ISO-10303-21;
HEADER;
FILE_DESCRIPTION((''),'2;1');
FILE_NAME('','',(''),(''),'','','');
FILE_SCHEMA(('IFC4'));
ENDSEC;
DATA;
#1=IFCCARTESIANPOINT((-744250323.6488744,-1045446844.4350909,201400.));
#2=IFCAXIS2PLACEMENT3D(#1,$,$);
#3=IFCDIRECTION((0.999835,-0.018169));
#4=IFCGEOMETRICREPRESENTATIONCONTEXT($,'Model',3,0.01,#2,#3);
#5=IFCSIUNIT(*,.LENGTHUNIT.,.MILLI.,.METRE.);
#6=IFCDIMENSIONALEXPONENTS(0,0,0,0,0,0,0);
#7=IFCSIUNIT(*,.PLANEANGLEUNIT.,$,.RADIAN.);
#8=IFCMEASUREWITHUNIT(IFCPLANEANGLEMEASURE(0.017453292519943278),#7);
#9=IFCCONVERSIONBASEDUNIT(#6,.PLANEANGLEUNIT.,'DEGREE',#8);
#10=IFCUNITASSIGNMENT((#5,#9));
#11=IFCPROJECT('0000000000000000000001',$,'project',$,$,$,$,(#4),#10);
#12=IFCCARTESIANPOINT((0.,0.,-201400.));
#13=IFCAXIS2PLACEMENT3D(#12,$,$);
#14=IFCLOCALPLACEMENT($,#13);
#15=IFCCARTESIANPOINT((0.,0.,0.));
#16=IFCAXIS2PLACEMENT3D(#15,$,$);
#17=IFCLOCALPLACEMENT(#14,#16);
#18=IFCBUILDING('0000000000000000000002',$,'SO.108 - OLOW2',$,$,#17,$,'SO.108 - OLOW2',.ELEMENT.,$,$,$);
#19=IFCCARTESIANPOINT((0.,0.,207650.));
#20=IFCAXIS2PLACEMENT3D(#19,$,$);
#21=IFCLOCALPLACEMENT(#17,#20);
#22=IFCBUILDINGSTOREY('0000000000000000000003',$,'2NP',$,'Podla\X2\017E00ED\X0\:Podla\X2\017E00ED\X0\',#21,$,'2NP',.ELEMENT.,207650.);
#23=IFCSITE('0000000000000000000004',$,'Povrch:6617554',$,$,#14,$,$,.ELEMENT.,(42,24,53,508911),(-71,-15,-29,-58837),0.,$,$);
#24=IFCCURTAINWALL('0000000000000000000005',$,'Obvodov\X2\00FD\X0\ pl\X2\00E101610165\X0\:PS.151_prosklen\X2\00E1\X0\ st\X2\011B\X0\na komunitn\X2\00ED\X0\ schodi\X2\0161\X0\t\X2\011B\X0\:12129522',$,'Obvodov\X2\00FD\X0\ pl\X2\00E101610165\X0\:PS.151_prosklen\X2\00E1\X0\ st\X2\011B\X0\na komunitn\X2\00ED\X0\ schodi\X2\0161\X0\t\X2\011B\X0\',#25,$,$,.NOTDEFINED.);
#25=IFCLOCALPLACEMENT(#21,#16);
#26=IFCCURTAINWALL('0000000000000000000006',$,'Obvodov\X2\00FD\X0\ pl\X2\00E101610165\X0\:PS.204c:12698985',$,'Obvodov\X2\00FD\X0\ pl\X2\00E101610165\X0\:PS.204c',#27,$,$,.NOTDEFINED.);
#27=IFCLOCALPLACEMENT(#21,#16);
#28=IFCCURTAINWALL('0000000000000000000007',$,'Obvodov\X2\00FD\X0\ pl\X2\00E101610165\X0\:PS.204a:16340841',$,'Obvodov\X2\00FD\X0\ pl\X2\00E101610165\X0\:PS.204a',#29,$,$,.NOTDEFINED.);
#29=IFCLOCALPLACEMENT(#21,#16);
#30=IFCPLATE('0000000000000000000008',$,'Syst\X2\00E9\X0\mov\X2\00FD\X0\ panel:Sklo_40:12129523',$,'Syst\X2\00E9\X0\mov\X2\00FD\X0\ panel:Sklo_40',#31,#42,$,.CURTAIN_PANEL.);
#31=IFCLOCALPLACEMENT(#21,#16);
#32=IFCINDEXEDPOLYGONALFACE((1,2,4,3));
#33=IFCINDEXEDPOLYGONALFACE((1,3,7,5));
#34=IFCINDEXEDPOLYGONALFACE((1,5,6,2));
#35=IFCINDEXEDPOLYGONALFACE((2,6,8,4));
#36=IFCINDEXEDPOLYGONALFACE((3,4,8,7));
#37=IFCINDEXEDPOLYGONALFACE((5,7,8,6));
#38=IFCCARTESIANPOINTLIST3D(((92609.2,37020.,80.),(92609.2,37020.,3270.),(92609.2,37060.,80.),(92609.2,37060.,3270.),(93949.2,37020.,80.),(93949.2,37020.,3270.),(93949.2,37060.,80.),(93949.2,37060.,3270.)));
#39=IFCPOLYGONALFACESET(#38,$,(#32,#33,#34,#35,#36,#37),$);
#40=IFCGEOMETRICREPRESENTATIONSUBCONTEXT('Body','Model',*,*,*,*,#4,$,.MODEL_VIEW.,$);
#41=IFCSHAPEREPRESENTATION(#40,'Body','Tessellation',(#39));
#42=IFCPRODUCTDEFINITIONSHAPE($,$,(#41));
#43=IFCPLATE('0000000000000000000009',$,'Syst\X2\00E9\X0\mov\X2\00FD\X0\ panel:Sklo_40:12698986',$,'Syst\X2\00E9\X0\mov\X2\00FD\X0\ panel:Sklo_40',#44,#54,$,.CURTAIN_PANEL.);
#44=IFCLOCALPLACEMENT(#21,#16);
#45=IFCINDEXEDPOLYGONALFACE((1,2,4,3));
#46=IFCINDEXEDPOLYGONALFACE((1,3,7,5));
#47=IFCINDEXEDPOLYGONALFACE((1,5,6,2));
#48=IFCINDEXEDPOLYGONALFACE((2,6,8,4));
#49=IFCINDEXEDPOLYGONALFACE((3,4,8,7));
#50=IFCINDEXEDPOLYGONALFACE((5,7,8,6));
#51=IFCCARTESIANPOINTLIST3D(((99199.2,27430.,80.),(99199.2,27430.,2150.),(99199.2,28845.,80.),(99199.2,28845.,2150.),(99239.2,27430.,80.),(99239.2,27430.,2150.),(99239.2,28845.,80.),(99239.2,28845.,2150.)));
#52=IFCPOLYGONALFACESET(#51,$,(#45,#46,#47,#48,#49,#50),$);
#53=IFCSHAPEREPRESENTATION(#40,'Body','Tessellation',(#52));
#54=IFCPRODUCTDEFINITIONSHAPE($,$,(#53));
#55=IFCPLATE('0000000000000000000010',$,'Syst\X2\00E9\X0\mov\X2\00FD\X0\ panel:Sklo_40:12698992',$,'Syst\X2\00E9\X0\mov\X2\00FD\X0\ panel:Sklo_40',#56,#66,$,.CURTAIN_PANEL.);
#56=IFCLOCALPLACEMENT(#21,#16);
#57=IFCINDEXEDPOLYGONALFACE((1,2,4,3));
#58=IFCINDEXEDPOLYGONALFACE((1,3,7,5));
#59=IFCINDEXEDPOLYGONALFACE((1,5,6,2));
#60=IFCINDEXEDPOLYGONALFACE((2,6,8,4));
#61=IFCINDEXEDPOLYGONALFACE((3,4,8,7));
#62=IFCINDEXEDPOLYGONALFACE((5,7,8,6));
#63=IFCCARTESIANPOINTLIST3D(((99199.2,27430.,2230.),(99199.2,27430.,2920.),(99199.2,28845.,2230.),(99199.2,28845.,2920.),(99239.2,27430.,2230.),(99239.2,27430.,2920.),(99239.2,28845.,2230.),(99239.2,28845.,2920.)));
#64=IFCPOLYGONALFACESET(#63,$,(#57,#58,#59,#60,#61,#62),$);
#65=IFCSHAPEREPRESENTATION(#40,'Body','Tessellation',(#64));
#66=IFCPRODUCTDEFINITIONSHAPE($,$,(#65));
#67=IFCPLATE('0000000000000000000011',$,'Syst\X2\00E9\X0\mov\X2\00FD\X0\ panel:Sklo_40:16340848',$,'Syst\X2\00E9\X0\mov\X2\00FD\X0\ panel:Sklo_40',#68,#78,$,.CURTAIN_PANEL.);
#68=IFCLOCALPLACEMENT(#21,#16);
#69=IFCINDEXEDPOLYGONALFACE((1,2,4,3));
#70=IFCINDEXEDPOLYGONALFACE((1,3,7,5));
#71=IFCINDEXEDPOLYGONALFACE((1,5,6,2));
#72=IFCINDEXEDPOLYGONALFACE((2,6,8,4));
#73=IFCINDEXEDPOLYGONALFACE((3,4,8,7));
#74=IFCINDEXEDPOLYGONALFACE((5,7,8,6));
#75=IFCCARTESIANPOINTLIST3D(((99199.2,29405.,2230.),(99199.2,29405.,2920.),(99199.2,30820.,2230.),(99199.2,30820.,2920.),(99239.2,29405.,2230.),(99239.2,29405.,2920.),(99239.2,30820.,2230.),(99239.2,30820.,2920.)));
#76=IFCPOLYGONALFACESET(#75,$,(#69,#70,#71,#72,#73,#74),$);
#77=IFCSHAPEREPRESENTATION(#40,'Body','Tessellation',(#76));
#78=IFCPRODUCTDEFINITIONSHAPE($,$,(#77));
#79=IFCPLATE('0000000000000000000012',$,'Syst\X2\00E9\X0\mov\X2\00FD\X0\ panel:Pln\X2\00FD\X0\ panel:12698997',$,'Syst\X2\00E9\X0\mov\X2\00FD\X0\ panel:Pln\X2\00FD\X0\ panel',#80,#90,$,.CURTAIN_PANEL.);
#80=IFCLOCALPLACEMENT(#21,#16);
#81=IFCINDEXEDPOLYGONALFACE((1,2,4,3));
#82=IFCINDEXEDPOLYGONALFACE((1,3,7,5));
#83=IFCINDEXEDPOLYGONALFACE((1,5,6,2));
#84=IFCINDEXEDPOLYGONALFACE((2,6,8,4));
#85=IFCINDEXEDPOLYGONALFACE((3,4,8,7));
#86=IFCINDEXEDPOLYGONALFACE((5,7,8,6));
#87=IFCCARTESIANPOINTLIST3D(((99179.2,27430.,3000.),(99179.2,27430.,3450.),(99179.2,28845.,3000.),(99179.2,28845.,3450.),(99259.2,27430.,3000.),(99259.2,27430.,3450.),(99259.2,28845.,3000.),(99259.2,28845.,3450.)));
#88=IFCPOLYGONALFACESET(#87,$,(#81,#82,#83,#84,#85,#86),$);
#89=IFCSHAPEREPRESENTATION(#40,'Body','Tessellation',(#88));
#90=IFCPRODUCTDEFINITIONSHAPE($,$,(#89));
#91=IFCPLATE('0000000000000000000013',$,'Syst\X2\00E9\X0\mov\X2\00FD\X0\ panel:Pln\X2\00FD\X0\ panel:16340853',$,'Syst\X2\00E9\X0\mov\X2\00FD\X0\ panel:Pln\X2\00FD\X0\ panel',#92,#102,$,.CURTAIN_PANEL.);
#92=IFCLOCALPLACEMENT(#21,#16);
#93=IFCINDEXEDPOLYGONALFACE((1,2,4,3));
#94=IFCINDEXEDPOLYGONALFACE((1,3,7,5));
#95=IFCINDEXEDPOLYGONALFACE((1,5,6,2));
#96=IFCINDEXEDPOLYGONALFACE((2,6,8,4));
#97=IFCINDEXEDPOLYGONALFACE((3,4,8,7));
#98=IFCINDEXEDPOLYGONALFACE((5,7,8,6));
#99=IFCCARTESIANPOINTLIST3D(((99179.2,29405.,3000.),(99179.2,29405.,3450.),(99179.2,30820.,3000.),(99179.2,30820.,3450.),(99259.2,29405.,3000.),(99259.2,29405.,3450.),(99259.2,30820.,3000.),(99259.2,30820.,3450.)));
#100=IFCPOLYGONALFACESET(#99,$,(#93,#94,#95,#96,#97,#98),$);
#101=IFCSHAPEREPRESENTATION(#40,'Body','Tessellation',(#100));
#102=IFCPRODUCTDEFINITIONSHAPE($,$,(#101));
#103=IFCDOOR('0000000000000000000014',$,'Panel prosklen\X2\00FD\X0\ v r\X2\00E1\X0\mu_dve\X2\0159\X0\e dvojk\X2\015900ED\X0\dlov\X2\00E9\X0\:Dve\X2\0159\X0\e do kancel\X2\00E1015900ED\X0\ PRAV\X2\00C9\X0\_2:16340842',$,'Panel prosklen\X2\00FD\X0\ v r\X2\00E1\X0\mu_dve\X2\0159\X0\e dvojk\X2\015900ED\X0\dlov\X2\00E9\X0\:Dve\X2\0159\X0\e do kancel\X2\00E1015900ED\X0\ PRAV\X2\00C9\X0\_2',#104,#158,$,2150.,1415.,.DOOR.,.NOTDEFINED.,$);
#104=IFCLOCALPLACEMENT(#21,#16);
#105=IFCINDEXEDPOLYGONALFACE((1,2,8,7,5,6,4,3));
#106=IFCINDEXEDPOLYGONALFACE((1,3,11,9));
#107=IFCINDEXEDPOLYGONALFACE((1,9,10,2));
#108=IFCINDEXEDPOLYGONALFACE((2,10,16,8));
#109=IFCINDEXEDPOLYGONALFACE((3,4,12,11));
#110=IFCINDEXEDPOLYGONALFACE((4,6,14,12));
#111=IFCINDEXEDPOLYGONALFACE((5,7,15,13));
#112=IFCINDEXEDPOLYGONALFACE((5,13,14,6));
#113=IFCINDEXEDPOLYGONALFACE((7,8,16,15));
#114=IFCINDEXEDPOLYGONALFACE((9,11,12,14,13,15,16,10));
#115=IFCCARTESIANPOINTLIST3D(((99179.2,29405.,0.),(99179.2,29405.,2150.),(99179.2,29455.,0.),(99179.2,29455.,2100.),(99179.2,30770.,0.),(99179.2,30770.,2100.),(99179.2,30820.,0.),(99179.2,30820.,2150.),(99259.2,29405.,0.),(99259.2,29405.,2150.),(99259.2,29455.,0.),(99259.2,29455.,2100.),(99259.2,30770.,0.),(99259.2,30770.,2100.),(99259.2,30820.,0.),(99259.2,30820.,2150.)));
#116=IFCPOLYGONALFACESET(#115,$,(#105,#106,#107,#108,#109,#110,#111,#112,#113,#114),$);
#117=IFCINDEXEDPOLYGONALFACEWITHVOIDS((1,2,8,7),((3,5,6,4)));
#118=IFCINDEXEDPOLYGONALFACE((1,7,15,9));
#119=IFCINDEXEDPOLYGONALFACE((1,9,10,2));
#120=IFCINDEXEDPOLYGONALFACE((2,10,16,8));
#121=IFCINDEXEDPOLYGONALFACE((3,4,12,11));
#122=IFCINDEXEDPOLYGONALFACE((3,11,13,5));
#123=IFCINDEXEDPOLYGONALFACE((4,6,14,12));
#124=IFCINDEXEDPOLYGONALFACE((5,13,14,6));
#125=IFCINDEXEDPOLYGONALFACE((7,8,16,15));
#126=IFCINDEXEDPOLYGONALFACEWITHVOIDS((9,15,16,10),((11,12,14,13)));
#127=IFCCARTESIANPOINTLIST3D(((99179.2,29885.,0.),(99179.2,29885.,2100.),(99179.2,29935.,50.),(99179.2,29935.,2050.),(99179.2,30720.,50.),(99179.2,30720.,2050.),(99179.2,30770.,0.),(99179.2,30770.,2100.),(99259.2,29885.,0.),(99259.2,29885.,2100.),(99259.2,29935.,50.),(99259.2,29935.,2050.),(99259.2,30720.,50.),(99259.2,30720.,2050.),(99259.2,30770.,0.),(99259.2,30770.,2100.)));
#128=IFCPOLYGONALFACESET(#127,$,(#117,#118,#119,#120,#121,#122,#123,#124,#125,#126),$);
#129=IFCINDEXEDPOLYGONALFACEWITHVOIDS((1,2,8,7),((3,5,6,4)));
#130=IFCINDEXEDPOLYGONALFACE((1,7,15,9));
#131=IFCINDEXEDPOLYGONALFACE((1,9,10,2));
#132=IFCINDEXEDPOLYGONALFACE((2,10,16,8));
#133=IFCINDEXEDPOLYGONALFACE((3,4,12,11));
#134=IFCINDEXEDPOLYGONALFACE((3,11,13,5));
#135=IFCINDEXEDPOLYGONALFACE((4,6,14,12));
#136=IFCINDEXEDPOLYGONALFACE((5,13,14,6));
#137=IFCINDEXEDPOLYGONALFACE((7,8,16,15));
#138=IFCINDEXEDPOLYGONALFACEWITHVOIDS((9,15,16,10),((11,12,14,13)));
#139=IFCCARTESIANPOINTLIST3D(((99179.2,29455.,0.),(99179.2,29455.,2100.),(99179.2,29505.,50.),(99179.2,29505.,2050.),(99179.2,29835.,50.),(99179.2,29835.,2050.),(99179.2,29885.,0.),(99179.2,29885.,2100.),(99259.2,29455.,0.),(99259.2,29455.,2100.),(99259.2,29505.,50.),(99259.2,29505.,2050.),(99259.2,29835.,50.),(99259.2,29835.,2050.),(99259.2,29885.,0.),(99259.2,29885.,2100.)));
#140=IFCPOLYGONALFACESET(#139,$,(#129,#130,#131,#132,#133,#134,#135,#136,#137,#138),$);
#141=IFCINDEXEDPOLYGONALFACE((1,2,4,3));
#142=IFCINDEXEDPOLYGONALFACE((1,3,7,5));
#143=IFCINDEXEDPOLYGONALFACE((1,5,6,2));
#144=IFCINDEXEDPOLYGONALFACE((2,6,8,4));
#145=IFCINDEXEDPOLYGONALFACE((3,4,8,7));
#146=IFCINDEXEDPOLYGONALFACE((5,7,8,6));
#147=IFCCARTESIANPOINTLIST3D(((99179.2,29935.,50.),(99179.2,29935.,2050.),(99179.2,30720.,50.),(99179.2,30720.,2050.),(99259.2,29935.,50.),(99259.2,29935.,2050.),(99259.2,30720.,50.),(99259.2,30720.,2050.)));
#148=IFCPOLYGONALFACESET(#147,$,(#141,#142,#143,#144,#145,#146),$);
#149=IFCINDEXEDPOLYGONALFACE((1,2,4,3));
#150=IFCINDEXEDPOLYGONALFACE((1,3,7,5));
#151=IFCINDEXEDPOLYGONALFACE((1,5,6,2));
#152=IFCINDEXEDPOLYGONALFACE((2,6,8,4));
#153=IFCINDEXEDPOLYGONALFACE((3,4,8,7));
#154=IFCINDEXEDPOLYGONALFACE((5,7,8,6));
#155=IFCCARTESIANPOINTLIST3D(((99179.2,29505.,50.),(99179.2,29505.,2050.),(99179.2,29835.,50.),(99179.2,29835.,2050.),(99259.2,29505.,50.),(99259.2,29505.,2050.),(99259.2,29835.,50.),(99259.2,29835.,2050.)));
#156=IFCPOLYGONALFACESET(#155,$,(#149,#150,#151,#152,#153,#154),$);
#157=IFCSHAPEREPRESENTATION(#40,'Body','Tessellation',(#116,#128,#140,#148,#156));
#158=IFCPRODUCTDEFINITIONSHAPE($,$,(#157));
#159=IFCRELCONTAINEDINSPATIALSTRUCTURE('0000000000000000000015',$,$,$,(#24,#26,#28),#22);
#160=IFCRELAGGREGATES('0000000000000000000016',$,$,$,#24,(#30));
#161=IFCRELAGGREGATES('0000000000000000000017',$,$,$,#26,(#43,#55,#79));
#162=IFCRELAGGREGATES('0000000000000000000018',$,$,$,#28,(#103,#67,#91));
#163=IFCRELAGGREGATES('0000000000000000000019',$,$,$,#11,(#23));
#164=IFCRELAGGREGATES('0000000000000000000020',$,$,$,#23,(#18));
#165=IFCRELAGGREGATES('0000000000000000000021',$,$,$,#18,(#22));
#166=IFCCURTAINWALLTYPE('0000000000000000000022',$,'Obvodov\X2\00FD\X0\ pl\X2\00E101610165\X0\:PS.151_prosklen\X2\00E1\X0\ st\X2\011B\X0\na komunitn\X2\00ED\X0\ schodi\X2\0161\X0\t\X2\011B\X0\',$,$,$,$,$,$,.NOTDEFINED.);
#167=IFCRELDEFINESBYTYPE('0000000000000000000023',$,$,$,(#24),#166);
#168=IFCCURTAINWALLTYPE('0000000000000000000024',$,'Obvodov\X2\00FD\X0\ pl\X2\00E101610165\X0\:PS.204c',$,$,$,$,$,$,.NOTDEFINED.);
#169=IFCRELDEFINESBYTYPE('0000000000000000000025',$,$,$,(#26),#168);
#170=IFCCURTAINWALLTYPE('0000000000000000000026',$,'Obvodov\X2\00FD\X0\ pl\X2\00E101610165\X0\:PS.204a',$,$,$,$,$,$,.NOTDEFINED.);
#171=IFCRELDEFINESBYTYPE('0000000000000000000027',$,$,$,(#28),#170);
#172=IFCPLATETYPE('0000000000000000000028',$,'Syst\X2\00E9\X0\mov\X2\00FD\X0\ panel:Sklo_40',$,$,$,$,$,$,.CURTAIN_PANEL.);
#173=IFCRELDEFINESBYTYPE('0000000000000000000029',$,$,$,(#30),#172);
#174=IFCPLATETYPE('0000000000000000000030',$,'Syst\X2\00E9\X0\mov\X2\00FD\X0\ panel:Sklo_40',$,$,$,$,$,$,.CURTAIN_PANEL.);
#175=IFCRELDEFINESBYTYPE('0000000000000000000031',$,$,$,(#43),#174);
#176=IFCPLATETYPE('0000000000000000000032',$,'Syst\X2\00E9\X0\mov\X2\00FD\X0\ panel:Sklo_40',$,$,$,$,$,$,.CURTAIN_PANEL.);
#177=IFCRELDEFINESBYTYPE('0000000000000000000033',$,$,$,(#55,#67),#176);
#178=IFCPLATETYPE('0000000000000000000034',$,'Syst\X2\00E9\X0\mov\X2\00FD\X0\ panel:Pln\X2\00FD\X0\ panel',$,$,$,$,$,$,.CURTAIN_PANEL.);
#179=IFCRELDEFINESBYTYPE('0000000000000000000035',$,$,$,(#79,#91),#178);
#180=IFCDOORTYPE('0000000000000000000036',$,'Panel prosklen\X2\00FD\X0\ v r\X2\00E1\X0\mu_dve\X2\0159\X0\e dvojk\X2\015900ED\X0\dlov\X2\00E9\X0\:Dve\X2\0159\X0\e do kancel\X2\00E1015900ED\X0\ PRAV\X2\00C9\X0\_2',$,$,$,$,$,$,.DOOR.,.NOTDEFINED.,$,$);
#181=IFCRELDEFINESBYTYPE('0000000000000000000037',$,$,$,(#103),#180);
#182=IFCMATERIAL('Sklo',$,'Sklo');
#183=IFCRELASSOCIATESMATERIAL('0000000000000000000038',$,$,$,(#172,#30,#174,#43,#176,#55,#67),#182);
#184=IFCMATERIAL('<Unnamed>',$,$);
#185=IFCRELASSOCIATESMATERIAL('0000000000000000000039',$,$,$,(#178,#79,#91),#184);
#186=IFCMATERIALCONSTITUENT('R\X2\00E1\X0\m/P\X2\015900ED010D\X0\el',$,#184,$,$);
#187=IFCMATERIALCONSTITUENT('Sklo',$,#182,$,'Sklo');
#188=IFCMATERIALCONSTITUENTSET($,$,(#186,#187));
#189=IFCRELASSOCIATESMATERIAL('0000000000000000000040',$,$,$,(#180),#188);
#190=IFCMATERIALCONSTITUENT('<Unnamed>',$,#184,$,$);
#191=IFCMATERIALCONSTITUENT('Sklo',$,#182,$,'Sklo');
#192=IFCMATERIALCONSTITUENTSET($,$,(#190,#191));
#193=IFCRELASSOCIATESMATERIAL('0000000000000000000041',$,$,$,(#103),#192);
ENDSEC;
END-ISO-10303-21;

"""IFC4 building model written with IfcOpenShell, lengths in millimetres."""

from ifc_helpers import new_model, entity, si_unit, converted_unit, direction, frame, origin, place, context, subcontext, project, spatial, indexed_curve, outline, extrude, source, transform, mapped, material, constituent, constituent_set, type_object, type_shapes, element, aggregate, save


model = new_model("IFC4")

# Units and contexts
model_context = context("Model", 3, precision=0.01, world=frame((-744250323.6488744, -1045446844.4350909, 201400.0)), true_north=direction((0.999835, -0.018169)))
body_context = subcontext(model_context, "Body", "Model", "MODEL_VIEW")
ifc_project = project(units=[si_unit("LENGTHUNIT", "METRE", prefix="MILLI"), converted_unit("PLANEANGLEUNIT", "DEGREE", entity("IfcPlaneAngleMeasure", 0.017453292519943278), si_unit("PLANEANGLEUNIT", "RADIAN"), dimensions=[0, 0, 0, 0, 0, 0, 0])], contexts=[model_context])

# Site, building, storey
site_placement = place(None, frame((0.0, 0.0, -201400.0)))
site = spatial("IfcSite", under=ifc_project, at=site_placement, Name="Povrch:6617554", CompositionType="ELEMENT", RefLatitude=(42, 24, 53, 508911), RefLongitude=(-71, -15, -29, -58837), RefElevation=0.0)
building_placement = place(site_placement, origin())
building = spatial("IfcBuilding", under=site, at=building_placement, Name="SO.108 - OLOW2", LongName="SO.108 - OLOW2", CompositionType="ELEMENT")
storey_placement = place(building_placement, frame((0.0, 0.0, 207650.0)))
storey = spatial("IfcBuildingStorey", under=building, at=storey_placement, Name="2NP", ObjectType="Podlaží:Podlaží", LongName="2NP", CompositionType="ELEMENT", Elevation=207650.0)

# Curtain wall
curtain_wall_type_1 = type_object("IfcCurtainWallType", Name="Obvodový plášť:PS.151_prosklená stěna komunitní schodiště", PredefinedType="NOTDEFINED")
curtain_wall_1_placement = place(storey_placement, frame((0.0, 0.0, -207650.0)))
curtain_wall_1 = element("IfcCurtainWall", 1, at=curtain_wall_1_placement, inside=storey, type_object=curtain_wall_type_1, Name="Obvodový plášť:PS.151_prosklená stěna komunitní schodiště:12129522", ObjectType="Obvodový plášť:PS.151_prosklená stěna komunitní schodiště", PredefinedType="NOTDEFINED")
ifc_material_1 = material(Name="<Unnamed>")

# Curtain walls
curtain_wall_type_2 = type_object("IfcCurtainWallType", Name="Obvodový plášť:PS.204c", PredefinedType="NOTDEFINED")
curtain_wall_2_placement = place(storey_placement, frame((0.0, 0.0, -207650.0)))
curtain_wall_2 = element("IfcCurtainWall", 2, at=curtain_wall_2_placement, inside=storey, type_object=curtain_wall_type_2, Name="Obvodový plášť:PS.204c:12698985", ObjectType="Obvodový plášť:PS.204c", PredefinedType="NOTDEFINED")
curtain_wall_type_3 = type_object("IfcCurtainWallType", Name="Obvodový plášť:PS.204a", PredefinedType="NOTDEFINED")
curtain_wall_3_placement = place(storey_placement, frame((0.0, 0.0, -207650.0)))
curtain_wall_3 = element("IfcCurtainWall", 3, at=curtain_wall_3_placement, inside=storey, type_object=curtain_wall_type_3, Name="Obvodový plášť:PS.204a:16340841", ObjectType="Obvodový plášť:PS.204a", PredefinedType="NOTDEFINED")

# Plates
ifc_material_2 = material(Name="Sklo", Category="Sklo")
plate_type_1 = type_object("IfcPlateType", Name="Systémový panel:Sklo_40", PredefinedType="CURTAIN_PANEL", material=ifc_material_2)
shared_shape_1 = source(origin(), body_context, "Body", "SweptSolid", [
    extrude(outline(indexed_curve([(-20.0, -670.0), (20.0, -670.0), (20.0, 670.0), (-20.0, 670.0), (-20.0, -670.0)], self_intersect=False)), frame((0.0, 0.0, 0.0), z_axis=(0.0, 0.0, 1.0), x_axis=(0.0, 1.0, 0.0)), (0.0, 0.0, 1.0), 3190.0),
])
type_shapes(plate_type_1, [shared_shape_1])
plate_1_placement = place(curtain_wall_1_placement, frame((93279.2, 37040.0, 207730.0)))
plate_1 = element("IfcPlate", 4, at=plate_1_placement, type_object=plate_type_1, material=ifc_material_2, Name="Systémový panel:Sklo_40:12129523", ObjectType="Systémový panel:Sklo_40", PredefinedType="CURTAIN_PANEL", context=body_context, shape_type="MappedRepresentation", body=[
    mapped(shared_shape_1, transform((0.0, 0.0, 0.0), scale=1.0)),
])
aggregate(curtain_wall_1, [plate_1])
plate_type_2 = type_object("IfcPlateType", Name="Systémový panel:Sklo_40", PredefinedType="CURTAIN_PANEL", material=ifc_material_2)
shared_shape_2 = source(origin(), body_context, "Body", "SweptSolid", [
    extrude(outline(indexed_curve([(-20.0, -707.5), (20.0, -707.5), (20.0, 707.5), (-20.0, 707.5), (-20.0, -707.5)], self_intersect=False)), frame((0.0, 0.0, 0.0), z_axis=(0.0, 0.0, 1.0), x_axis=(0.0, 1.0, 0.0)), (0.0, 0.0, 1.0), 2070.0),
])
type_shapes(plate_type_2, [shared_shape_2])
plate_2_placement = place(curtain_wall_2_placement, frame((99219.2, 28137.5, 207730.0), z_axis=(0.0, 0.0, 1.0), x_axis=(0.0, -1.0, 0.0)))
plate_2 = element("IfcPlate", 5, at=plate_2_placement, type_object=plate_type_2, material=ifc_material_2, Name="Systémový panel:Sklo_40:12698986", ObjectType="Systémový panel:Sklo_40", PredefinedType="CURTAIN_PANEL", context=body_context, shape_type="MappedRepresentation", body=[
    mapped(shared_shape_2, transform((0.0, 0.0, 0.0), scale=1.0)),
])
plate_type_3 = type_object("IfcPlateType", Name="Systémový panel:Sklo_40", PredefinedType="CURTAIN_PANEL", material=ifc_material_2)
shared_shape_3 = source(origin(), body_context, "Body", "SweptSolid", [
    extrude(outline(indexed_curve([(-20.0, -707.5), (20.0, -707.5), (20.0, 707.5), (-20.0, 707.5), (-20.0, -707.5)], self_intersect=False)), frame((0.0, 0.0, 0.0), z_axis=(0.0, 0.0, 1.0), x_axis=(0.0, 1.0, 0.0)), (0.0, 0.0, 1.0), 690.0),
])
type_shapes(plate_type_3, [shared_shape_3])
plate_3_placement = place(curtain_wall_2_placement, frame((99219.2, 28137.5, 209880.0), z_axis=(0.0, 0.0, 1.0), x_axis=(0.0, -1.0, 0.0)))
plate_3 = element("IfcPlate", 6, at=plate_3_placement, type_object=plate_type_3, material=ifc_material_2, Name="Systémový panel:Sklo_40:12698992", ObjectType="Systémový panel:Sklo_40", PredefinedType="CURTAIN_PANEL", context=body_context, shape_type="MappedRepresentation", body=[
    mapped(shared_shape_3, transform((0.0, 0.0, 0.0), scale=1.0)),
])
plate_4_placement = place(curtain_wall_3_placement, frame((99219.2, 30112.5, 209880.0), z_axis=(0.0, 0.0, 1.0), x_axis=(0.0, 1.0, 0.0)))
plate_4 = element("IfcPlate", 7, at=plate_4_placement, type_object=plate_type_3, material=ifc_material_2, Name="Systémový panel:Sklo_40:16340848", ObjectType="Systémový panel:Sklo_40", PredefinedType="CURTAIN_PANEL", context=body_context, shape_type="MappedRepresentation", body=[
    mapped(shared_shape_3, transform((0.0, 0.0, 0.0), scale=1.0)),
])
plate_type_4 = type_object("IfcPlateType", Name="Systémový panel:Plný panel", PredefinedType="CURTAIN_PANEL", material=ifc_material_1)
shared_shape_4 = source(origin(), body_context, "Body", "SweptSolid", [
    extrude(outline(indexed_curve([(-40.0, -707.5), (40.0, -707.5), (40.0, 707.5), (-40.0, 707.5), (-40.0, -707.5)], self_intersect=False)), frame((0.0, 0.0, 0.0), z_axis=(0.0, 0.0, 1.0), x_axis=(0.0, 1.0, 0.0)), (0.0, 0.0, 1.0), 450.0),
])
type_shapes(plate_type_4, [shared_shape_4])
plate_5_placement = place(curtain_wall_2_placement, frame((99219.2, 28137.5, 210650.0), z_axis=(0.0, 0.0, 1.0), x_axis=(0.0, -1.0, 0.0)))
plate_5 = element("IfcPlate", 8, at=plate_5_placement, type_object=plate_type_4, material=ifc_material_1, Name="Systémový panel:Plný panel:12698997", ObjectType="Systémový panel:Plný panel", PredefinedType="CURTAIN_PANEL", context=body_context, shape_type="MappedRepresentation", body=[
    mapped(shared_shape_4, transform((0.0, 0.0, 0.0), scale=1.0)),
])
aggregate(curtain_wall_2, [plate_2, plate_3, plate_5])
plate_6_placement = place(curtain_wall_3_placement, frame((99219.2, 30112.5, 210650.0), z_axis=(0.0, 0.0, 1.0), x_axis=(0.0, 1.0, 0.0)))
plate_6 = element("IfcPlate", 9, at=plate_6_placement, type_object=plate_type_4, material=ifc_material_1, Name="Systémový panel:Plný panel:16340853", ObjectType="Systémový panel:Plný panel", PredefinedType="CURTAIN_PANEL", context=body_context, shape_type="MappedRepresentation", body=[
    mapped(shared_shape_4, transform((0.0, 0.0, 0.0), scale=1.0)),
])

# Door
ifc_constituent_1 = constituent(ifc_material_1, Name="<Unnamed>")
ifc_constituent_2 = constituent(ifc_material_2, Name="Sklo", Category="Sklo")
ifc_constituent_set_1 = constituent_set(constituents=[ifc_constituent_1, ifc_constituent_2])
ifc_constituent_3 = constituent(ifc_material_1, Name="Rám/Příčel")
ifc_constituent_4 = constituent(ifc_material_2, Name="Sklo", Category="Sklo")
ifc_constituent_set_2 = constituent_set(constituents=[ifc_constituent_3, ifc_constituent_4])
door_type = type_object("IfcDoorType", Name="Panel prosklený v rámu_dveře dvojkřídlové:Dveře do kanceláří PRAVÉ_2", OperationType="NOTDEFINED", PredefinedType="DOOR", material=ifc_constituent_set_2)
shared_shape_5 = source(origin(), body_context, "Body", "SweptSolid", [
    extrude(outline(indexed_curve([(-707.5, -1087.5), (707.5, -1087.5), (707.5, 1062.5), (657.5, 1062.5), (657.5, -1037.5), (-657.5, -1037.5), (-657.5, 1062.5), (-707.5, 1062.5), (-707.5, -1087.5)], self_intersect=False)), frame((0.0, -40.0, 1062.5), z_axis=(0.0, 1.0, 0.0), x_axis=(1.0, 0.0, 0.0)), (0.0, 0.0, 1.0), 80.0),
    extrude(outline(indexed_curve([(-1050.0, -442.5), (1050.0, -442.5), (1050.0, 442.5), (-1050.0, 442.5), (-1050.0, -442.5)], self_intersect=False), holes=[indexed_curve([(-1000.0, -392.5), (-1000.0, 392.5), (1000.0, 392.5), (1000.0, -392.5), (-1000.0, -392.5)], self_intersect=False)]), frame((215.0, -40.0, 1050.0), z_axis=(0.0, 1.0, 0.0), x_axis=(0.0, 0.0, -1.0)), (0.0, 0.0, 1.0), 80.0),
    extrude(outline(indexed_curve([(-1050.0, -215.0), (1050.0, -215.0), (1050.0, 215.0), (-1050.0, 215.0), (-1050.0, -215.0)], self_intersect=False), holes=[indexed_curve([(-1000.0, -165.0), (-1000.0, 165.0), (1000.0, 165.0), (1000.0, -165.0), (-1000.0, -165.0)], self_intersect=False)]), frame((-442.5, -40.0, 1050.0), z_axis=(0.0, 1.0, 0.0), x_axis=(0.0, 0.0, -1.0)), (0.0, 0.0, 1.0), 80.0),
    extrude(outline(indexed_curve([(-40.0, -392.5), (40.0, -392.5), (40.0, 392.5), (-40.0, 392.5), (-40.0, -392.5)], self_intersect=False)), frame((215.0, 0.0, 50.0), z_axis=(0.0, 0.0, 1.0), x_axis=(0.0, 1.0, 0.0)), (0.0, 0.0, 1.0), 2000.0),
    extrude(outline(indexed_curve([(-40.0, -165.0), (40.0, -165.0), (40.0, 165.0), (-40.0, 165.0), (-40.0, -165.0)], self_intersect=False)), frame((-442.5, 0.0, 50.0), z_axis=(0.0, 0.0, 1.0), x_axis=(0.0, 1.0, 0.0)), (0.0, 0.0, 1.0), 2000.0),
])
type_shapes(door_type, [shared_shape_5])
door_placement = place(curtain_wall_3_placement, frame((99219.2, 30112.5, 207650.0), z_axis=(0.0, 0.0, 1.0), x_axis=(0.0, 1.0, 0.0)))
door = element("IfcDoor", 10, at=door_placement, type_object=door_type, material=ifc_constituent_set_1, Name="Panel prosklený v rámu_dveře dvojkřídlové:Dveře do kanceláří PRAVÉ_2:16340842", ObjectType="Panel prosklený v rámu_dveře dvojkřídlové:Dveře do kanceláří PRAVÉ_2", OperationType="NOTDEFINED", OverallHeight=2150.0, OverallWidth=1415.0, PredefinedType="DOOR", context=body_context, shape_type="MappedRepresentation", body=[
    mapped(shared_shape_5, transform((0.0, 0.0, 0.0), scale=1.0)),
])
aggregate(curtain_wall_3, [door, plate_4, plate_6])

save(model, "model.ifc")
